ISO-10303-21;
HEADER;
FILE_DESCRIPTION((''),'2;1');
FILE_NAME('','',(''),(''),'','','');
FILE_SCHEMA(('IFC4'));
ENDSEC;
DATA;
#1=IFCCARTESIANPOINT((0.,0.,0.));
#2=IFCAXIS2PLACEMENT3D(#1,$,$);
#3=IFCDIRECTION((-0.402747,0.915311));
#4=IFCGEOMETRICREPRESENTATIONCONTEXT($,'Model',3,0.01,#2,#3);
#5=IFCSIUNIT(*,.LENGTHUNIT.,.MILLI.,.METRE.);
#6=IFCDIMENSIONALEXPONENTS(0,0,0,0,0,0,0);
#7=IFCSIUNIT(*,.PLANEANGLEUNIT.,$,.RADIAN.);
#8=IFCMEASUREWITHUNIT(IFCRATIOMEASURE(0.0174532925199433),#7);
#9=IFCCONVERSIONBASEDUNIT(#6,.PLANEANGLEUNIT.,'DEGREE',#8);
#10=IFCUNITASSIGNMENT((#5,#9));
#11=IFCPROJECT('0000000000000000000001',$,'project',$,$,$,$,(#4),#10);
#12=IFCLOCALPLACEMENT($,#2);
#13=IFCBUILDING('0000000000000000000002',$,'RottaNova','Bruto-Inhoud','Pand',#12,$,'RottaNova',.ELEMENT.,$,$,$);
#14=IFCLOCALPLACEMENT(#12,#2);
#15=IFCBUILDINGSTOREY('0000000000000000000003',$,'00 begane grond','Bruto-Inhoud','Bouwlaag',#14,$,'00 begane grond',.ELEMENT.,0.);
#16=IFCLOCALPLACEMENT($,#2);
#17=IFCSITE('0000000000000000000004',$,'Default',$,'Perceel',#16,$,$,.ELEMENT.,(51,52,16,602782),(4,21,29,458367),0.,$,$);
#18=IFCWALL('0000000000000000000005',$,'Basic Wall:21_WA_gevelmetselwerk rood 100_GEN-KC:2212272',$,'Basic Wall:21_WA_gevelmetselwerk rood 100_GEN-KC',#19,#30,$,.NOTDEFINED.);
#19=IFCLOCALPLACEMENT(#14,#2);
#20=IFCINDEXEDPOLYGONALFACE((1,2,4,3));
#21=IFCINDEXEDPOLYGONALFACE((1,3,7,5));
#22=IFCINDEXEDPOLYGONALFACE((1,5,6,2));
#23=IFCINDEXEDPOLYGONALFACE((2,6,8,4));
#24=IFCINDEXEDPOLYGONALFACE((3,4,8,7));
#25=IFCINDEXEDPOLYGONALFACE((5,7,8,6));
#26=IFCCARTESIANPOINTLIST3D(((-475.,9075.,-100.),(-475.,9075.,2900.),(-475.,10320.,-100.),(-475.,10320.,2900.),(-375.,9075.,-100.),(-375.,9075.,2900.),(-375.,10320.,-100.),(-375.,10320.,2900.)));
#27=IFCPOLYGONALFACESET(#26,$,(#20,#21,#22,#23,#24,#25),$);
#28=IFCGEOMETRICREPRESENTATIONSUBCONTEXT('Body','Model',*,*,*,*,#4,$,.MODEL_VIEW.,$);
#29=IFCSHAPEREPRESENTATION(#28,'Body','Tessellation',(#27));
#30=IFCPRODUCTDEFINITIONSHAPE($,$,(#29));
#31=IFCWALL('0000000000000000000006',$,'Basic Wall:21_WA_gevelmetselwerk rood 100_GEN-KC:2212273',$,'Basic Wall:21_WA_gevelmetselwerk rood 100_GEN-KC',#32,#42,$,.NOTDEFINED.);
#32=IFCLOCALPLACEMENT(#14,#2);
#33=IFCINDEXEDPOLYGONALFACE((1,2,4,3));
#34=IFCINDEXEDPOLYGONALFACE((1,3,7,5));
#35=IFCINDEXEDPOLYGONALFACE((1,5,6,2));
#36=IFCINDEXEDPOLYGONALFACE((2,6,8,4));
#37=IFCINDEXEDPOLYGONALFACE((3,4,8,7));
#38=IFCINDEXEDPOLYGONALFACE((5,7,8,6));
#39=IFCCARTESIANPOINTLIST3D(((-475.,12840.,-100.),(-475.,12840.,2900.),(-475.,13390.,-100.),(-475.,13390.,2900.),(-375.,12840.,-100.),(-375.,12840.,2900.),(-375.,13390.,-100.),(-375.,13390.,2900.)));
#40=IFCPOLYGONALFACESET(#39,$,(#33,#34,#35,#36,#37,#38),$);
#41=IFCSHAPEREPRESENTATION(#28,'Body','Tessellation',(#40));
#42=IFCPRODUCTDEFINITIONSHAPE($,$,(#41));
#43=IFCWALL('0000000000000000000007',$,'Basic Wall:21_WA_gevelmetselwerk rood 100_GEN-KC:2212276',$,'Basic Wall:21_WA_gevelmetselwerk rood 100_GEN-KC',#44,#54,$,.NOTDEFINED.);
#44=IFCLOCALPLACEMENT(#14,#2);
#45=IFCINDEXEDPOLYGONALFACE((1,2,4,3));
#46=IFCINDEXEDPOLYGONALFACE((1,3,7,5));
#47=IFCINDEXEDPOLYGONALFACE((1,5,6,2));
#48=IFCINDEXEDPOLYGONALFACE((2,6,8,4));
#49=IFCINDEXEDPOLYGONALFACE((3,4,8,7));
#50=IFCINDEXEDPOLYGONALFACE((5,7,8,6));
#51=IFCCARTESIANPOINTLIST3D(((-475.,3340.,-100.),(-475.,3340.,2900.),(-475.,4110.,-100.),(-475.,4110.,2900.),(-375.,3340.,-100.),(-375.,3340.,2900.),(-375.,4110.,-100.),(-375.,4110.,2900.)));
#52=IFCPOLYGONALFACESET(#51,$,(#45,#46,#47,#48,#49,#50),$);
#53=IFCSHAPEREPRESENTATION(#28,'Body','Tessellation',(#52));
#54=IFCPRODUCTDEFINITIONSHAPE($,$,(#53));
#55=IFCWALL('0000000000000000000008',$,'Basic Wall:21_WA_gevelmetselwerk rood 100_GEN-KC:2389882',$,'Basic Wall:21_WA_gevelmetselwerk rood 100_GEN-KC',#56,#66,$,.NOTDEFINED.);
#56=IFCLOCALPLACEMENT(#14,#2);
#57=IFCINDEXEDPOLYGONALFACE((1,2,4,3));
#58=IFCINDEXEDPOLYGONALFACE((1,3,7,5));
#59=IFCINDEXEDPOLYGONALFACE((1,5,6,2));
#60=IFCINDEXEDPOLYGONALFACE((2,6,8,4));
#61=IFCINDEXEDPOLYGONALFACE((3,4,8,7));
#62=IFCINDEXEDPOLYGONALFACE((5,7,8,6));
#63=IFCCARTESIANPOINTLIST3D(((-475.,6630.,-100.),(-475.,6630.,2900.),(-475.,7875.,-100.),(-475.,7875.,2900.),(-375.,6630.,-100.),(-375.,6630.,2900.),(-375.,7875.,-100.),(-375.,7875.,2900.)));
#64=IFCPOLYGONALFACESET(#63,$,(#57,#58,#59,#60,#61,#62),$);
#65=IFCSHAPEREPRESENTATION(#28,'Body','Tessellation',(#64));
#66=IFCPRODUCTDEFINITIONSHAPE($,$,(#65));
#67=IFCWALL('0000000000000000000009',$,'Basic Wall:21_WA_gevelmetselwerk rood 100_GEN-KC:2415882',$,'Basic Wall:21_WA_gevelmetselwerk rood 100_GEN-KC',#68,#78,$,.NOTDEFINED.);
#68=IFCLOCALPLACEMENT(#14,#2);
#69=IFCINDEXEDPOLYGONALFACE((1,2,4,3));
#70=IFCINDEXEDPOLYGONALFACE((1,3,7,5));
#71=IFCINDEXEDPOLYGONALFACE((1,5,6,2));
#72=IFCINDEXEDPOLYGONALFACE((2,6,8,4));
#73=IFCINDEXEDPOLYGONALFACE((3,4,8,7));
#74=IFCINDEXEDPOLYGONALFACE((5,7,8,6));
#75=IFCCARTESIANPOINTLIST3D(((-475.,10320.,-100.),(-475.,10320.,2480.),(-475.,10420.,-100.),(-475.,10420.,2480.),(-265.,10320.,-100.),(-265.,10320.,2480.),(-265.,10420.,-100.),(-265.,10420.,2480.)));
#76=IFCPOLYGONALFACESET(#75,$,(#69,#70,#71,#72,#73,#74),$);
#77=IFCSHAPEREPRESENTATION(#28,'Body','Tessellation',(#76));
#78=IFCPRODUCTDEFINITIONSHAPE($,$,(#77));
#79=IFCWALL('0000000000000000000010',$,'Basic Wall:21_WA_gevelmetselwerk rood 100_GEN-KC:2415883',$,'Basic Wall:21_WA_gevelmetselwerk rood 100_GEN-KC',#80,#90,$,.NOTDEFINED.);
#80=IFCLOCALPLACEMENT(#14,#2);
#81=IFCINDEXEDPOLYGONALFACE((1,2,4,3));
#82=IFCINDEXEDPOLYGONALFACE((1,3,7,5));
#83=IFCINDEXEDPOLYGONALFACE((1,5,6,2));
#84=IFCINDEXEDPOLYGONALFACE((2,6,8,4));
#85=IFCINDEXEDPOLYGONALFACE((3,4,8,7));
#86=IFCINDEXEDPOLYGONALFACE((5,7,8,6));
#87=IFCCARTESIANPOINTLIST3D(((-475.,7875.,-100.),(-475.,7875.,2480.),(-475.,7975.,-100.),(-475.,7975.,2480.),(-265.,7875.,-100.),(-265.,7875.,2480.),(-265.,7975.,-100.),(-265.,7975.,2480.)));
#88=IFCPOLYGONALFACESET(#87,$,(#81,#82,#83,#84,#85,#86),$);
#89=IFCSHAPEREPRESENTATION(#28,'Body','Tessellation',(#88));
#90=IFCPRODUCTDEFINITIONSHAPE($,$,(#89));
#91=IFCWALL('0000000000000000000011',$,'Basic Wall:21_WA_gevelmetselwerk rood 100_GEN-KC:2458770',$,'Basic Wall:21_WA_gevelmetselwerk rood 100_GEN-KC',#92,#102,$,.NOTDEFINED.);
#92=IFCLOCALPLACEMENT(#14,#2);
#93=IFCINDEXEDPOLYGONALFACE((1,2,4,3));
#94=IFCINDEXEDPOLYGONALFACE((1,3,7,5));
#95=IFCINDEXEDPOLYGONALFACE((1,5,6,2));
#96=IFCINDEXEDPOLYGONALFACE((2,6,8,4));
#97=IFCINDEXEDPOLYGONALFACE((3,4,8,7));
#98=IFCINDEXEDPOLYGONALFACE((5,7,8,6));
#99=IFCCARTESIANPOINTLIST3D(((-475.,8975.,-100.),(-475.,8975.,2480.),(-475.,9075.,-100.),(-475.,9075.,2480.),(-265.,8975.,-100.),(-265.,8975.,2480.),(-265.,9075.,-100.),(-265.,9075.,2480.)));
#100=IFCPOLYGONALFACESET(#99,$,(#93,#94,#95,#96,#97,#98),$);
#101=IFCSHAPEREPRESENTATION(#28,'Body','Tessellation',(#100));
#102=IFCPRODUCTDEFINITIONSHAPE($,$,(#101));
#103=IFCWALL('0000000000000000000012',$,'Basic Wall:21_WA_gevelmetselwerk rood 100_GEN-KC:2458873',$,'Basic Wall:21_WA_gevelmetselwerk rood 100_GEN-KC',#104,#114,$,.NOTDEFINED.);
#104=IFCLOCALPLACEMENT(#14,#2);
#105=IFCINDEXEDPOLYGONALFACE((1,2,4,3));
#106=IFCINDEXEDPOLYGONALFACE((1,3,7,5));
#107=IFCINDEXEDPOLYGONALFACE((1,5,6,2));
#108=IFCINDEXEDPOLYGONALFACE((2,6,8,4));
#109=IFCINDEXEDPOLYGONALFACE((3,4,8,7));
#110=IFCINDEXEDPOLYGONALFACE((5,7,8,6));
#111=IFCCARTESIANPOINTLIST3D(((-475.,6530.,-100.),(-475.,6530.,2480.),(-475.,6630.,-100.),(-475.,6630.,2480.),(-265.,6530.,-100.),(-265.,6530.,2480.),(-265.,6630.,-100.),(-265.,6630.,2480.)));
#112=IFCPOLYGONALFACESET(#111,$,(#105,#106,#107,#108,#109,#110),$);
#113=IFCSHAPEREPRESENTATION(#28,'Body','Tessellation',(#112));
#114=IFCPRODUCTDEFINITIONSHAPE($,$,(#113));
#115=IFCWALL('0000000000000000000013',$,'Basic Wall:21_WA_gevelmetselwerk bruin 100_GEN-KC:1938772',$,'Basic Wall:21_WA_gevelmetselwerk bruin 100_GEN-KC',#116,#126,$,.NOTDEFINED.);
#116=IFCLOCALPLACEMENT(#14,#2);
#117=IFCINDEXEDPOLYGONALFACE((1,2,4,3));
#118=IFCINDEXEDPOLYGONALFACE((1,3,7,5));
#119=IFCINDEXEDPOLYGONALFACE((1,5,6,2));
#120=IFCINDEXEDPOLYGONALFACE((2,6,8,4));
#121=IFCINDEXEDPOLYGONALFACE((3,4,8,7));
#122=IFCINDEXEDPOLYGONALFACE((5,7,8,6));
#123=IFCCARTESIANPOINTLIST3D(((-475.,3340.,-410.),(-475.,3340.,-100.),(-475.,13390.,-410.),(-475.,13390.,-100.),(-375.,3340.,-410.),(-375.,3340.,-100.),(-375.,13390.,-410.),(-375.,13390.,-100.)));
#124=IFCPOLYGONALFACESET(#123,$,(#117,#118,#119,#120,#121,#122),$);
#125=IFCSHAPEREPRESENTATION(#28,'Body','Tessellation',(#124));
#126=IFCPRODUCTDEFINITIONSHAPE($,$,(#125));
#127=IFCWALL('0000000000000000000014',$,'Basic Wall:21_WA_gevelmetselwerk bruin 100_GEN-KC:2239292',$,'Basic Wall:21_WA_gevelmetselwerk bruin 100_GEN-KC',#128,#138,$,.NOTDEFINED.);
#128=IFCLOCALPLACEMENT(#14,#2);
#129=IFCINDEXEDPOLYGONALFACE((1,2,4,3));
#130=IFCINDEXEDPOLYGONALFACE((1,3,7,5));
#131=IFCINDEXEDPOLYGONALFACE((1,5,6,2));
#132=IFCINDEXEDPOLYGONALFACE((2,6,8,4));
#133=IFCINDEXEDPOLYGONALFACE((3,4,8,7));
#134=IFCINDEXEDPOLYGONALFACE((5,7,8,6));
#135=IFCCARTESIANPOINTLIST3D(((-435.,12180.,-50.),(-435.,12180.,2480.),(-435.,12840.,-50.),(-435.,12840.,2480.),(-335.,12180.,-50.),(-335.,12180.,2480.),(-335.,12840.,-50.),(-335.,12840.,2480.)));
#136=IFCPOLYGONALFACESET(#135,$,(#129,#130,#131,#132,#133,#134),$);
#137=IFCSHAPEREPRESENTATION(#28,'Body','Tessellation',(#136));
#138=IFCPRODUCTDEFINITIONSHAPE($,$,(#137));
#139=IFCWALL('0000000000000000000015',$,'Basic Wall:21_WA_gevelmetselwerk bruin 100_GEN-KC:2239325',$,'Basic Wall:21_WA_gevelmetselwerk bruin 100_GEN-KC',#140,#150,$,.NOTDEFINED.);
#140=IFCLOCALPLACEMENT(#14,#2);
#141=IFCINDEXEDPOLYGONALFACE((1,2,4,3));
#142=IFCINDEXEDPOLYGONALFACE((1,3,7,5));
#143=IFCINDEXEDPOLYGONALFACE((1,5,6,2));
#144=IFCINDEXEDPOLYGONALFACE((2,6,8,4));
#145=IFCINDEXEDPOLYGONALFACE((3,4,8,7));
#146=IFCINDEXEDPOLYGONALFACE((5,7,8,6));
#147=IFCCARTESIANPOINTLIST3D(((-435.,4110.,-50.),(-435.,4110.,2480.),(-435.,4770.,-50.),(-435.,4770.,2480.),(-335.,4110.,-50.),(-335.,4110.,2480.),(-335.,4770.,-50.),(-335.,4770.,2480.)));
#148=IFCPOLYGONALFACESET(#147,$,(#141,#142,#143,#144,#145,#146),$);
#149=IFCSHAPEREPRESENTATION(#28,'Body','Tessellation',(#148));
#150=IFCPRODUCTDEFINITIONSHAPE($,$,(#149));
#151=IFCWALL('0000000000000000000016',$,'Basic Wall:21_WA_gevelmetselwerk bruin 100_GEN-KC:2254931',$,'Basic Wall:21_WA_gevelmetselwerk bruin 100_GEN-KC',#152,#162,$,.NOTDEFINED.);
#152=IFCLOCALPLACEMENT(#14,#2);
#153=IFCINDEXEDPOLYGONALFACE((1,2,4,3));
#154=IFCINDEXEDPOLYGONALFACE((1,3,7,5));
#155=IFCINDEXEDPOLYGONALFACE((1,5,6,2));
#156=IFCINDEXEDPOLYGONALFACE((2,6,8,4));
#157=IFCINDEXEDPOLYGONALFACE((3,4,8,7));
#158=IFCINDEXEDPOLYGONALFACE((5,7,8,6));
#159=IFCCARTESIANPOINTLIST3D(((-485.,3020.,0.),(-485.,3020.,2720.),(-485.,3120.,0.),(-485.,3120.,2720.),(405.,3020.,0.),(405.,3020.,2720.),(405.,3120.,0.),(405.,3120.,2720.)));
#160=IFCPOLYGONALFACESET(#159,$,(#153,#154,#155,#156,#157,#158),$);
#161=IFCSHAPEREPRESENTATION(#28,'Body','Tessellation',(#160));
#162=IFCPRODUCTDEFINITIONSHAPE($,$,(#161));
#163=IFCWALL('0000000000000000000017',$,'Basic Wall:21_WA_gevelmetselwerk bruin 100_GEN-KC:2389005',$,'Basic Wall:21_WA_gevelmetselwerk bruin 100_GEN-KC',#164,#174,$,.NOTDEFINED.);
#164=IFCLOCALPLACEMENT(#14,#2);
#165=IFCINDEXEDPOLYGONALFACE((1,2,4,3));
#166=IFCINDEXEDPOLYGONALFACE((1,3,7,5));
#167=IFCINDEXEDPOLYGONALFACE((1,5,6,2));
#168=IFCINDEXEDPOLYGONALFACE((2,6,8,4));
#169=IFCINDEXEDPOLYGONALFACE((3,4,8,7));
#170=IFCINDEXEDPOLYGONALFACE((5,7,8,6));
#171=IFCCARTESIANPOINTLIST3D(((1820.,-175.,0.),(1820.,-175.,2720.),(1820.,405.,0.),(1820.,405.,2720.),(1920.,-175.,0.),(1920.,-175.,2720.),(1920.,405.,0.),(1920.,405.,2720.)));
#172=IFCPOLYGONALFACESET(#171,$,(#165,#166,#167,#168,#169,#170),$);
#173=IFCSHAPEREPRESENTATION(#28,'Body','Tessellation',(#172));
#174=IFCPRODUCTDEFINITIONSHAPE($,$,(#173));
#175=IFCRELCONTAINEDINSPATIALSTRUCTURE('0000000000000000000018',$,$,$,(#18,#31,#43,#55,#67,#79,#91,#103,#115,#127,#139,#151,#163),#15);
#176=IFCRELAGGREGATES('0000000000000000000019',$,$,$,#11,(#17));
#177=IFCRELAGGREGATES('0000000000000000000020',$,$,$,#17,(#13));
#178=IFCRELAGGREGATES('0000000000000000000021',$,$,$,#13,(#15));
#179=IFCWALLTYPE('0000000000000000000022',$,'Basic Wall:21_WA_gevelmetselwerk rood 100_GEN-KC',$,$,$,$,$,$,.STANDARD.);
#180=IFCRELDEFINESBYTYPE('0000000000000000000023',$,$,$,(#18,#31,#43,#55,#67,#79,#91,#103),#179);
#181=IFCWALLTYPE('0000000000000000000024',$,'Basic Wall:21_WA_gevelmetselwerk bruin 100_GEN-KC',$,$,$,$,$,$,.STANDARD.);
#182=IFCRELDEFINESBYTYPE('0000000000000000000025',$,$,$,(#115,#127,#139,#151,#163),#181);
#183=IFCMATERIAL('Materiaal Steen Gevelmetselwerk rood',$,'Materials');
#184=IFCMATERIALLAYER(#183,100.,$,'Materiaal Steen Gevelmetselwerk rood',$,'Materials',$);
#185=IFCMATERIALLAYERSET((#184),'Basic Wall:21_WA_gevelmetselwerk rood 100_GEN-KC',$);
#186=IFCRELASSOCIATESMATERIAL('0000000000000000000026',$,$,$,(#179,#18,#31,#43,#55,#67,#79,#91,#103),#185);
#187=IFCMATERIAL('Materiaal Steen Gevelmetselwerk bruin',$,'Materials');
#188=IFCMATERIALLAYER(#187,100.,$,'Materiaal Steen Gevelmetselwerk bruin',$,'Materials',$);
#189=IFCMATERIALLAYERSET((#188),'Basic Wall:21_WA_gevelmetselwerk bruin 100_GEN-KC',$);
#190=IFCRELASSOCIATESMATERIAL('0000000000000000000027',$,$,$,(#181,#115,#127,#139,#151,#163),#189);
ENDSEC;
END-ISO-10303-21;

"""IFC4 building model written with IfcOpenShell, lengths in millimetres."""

from ifc_helpers import new_model, entity, si_unit, converted_unit, direction, frame, frame_2d, origin, place, context, subcontext, project, spatial, rectangle, extrude, material, layer, layer_set, type_object, element, save


model = new_model("IFC4")

# Units and contexts
model_context = context("Model", 3, precision=0.01, world=origin(), true_north=direction((-0.402747, 0.915311)))
body_context = subcontext(model_context, "Body", "Model", "MODEL_VIEW")
ifc_project = project(units=[si_unit("LENGTHUNIT", "METRE", prefix="MILLI"), converted_unit("PLANEANGLEUNIT", "DEGREE", entity("IfcRatioMeasure", 0.0174532925199433), si_unit("PLANEANGLEUNIT", "RADIAN"), dimensions=[0, 0, 0, 0, 0, 0, 0])], contexts=[model_context])

# Site, building, storey
site_placement = place(None, origin())
site = spatial("IfcSite", under=ifc_project, at=site_placement, Name="Default", ObjectType="Perceel", CompositionType="ELEMENT", RefLatitude=(51, 52, 16, 602782), RefLongitude=(4, 21, 29, 458367), RefElevation=0.0)
building_placement = place(None, origin())
building = spatial("IfcBuilding", under=site, at=building_placement, Name="RottaNova", Description="Bruto-Inhoud", ObjectType="Pand", LongName="RottaNova", CompositionType="ELEMENT")
storey_placement = place(building_placement, origin())
storey = spatial("IfcBuildingStorey", under=building, at=storey_placement, Name="00 begane grond", Description="Bruto-Inhoud", ObjectType="Bouwlaag", LongName="00 begane grond", CompositionType="ELEMENT", Elevation=0.0)

# Walls
ifc_material_1 = material(Name="Materiaal Steen Gevelmetselwerk rood", Category="Materials")
ifc_layer_1 = layer(ifc_material_1, 100.0, Name="Materiaal Steen Gevelmetselwerk rood", Category="Materials")
ifc_layer_set_1 = layer_set([ifc_layer_1], Name="Basic Wall:21_WA_gevelmetselwerk rood 100_GEN-KC")
wall_type_1 = type_object("IfcWallType", Name="Basic Wall:21_WA_gevelmetselwerk rood 100_GEN-KC", PredefinedType="STANDARD", material=ifc_layer_set_1)
wall_1_placement = place(storey_placement, frame((-425.0, 9075.0, -100.0), z_axis=(0.0, 0.0, 1.0), x_axis=(0.0, 1.0, 0.0)))
element("IfcWall", 1, at=wall_1_placement, inside=storey, type_object=wall_type_1, material=ifc_layer_set_1, Name="Basic Wall:21_WA_gevelmetselwerk rood 100_GEN-KC:2212272", ObjectType="Basic Wall:21_WA_gevelmetselwerk rood 100_GEN-KC", PredefinedType="NOTDEFINED", context=body_context, shape_type="SweptSolid", body=[
    extrude(rectangle(XDim=1245.0, YDim=100.0, at=frame_2d((622.5, 0.0), x_axis=(-1.0, 0.0))), origin(), (0.0, 0.0, 1.0), 3000.0),
])
wall_2_placement = place(storey_placement, frame((-425.0, 12840.0, -100.0), z_axis=(0.0, 0.0, 1.0), x_axis=(0.0, 1.0, 0.0)))
element("IfcWall", 2, at=wall_2_placement, inside=storey, type_object=wall_type_1, material=ifc_layer_set_1, Name="Basic Wall:21_WA_gevelmetselwerk rood 100_GEN-KC:2212273", ObjectType="Basic Wall:21_WA_gevelmetselwerk rood 100_GEN-KC", PredefinedType="NOTDEFINED", context=body_context, shape_type="SweptSolid", body=[
    extrude(rectangle(XDim=550.0, YDim=100.0, at=frame_2d((275.0, 0.0), x_axis=(-1.0, 0.0))), origin(), (0.0, 0.0, 1.0), 3000.0),
])
wall_3_placement = place(storey_placement, frame((-425.0, 3340.0, -100.0), z_axis=(0.0, 0.0, 1.0), x_axis=(0.0, 1.0, 0.0)))
element("IfcWall", 3, at=wall_3_placement, inside=storey, type_object=wall_type_1, material=ifc_layer_set_1, Name="Basic Wall:21_WA_gevelmetselwerk rood 100_GEN-KC:2212276", ObjectType="Basic Wall:21_WA_gevelmetselwerk rood 100_GEN-KC", PredefinedType="NOTDEFINED", context=body_context, shape_type="SweptSolid", body=[
    extrude(rectangle(XDim=770.0, YDim=100.0, at=frame_2d((385.0, 0.0), x_axis=(-1.0, 0.0))), origin(), (0.0, 0.0, 1.0), 3000.0),
])
wall_4_placement = place(storey_placement, frame((-425.0, 6630.0, -100.0), z_axis=(0.0, 0.0, 1.0), x_axis=(0.0, 1.0, 0.0)))
element("IfcWall", 4, at=wall_4_placement, inside=storey, type_object=wall_type_1, material=ifc_layer_set_1, Name="Basic Wall:21_WA_gevelmetselwerk rood 100_GEN-KC:2389882", ObjectType="Basic Wall:21_WA_gevelmetselwerk rood 100_GEN-KC", PredefinedType="NOTDEFINED", context=body_context, shape_type="SweptSolid", body=[
    extrude(rectangle(XDim=1245.0, YDim=100.0, at=frame_2d((622.5, 0.0), x_axis=(-1.0, 0.0))), origin(), (0.0, 0.0, 1.0), 3000.0),
])
wall_5_placement = place(storey_placement, frame((-475.0, 10370.0, -100.0)))
element("IfcWall", 5, at=wall_5_placement, inside=storey, type_object=wall_type_1, material=ifc_layer_set_1, Name="Basic Wall:21_WA_gevelmetselwerk rood 100_GEN-KC:2415882", ObjectType="Basic Wall:21_WA_gevelmetselwerk rood 100_GEN-KC", PredefinedType="NOTDEFINED", context=body_context, shape_type="SweptSolid", body=[
    extrude(rectangle(XDim=210.0, YDim=100.0, at=frame_2d((105.0, 0.0), x_axis=(-1.0, 0.0))), origin(), (0.0, 0.0, 1.0), 2580.0),
])
wall_6_placement = place(storey_placement, frame((-475.0, 7925.0, -100.0)))
element("IfcWall", 6, at=wall_6_placement, inside=storey, type_object=wall_type_1, material=ifc_layer_set_1, Name="Basic Wall:21_WA_gevelmetselwerk rood 100_GEN-KC:2415883", ObjectType="Basic Wall:21_WA_gevelmetselwerk rood 100_GEN-KC", PredefinedType="NOTDEFINED", context=body_context, shape_type="SweptSolid", body=[
    extrude(rectangle(XDim=210.0, YDim=100.0, at=frame_2d((105.0, 0.0), x_axis=(-1.0, 0.0))), origin(), (0.0, 0.0, 1.0), 2580.0),
])
wall_7_placement = place(storey_placement, frame((-475.0, 9025.0, -100.0)))
element("IfcWall", 7, at=wall_7_placement, inside=storey, type_object=wall_type_1, material=ifc_layer_set_1, Name="Basic Wall:21_WA_gevelmetselwerk rood 100_GEN-KC:2458770", ObjectType="Basic Wall:21_WA_gevelmetselwerk rood 100_GEN-KC", PredefinedType="NOTDEFINED", context=body_context, shape_type="SweptSolid", body=[
    extrude(rectangle(XDim=210.0, YDim=100.0, at=frame_2d((105.0, 0.0), x_axis=(-1.0, 0.0))), origin(), (0.0, 0.0, 1.0), 2580.0),
])
wall_8_placement = place(storey_placement, frame((-475.0, 6580.0, -100.0)))
element("IfcWall", 8, at=wall_8_placement, inside=storey, type_object=wall_type_1, material=ifc_layer_set_1, Name="Basic Wall:21_WA_gevelmetselwerk rood 100_GEN-KC:2458873", ObjectType="Basic Wall:21_WA_gevelmetselwerk rood 100_GEN-KC", PredefinedType="NOTDEFINED", context=body_context, shape_type="SweptSolid", body=[
    extrude(rectangle(XDim=210.0, YDim=100.0, at=frame_2d((105.0, 0.0), x_axis=(-1.0, 0.0))), origin(), (0.0, 0.0, 1.0), 2580.0),
])
ifc_material_2 = material(Name="Materiaal Steen Gevelmetselwerk bruin", Category="Materials")
ifc_layer_2 = layer(ifc_material_2, 100.0, Name="Materiaal Steen Gevelmetselwerk bruin", Category="Materials")
ifc_layer_set_2 = layer_set([ifc_layer_2], Name="Basic Wall:21_WA_gevelmetselwerk bruin 100_GEN-KC")
wall_type_2 = type_object("IfcWallType", Name="Basic Wall:21_WA_gevelmetselwerk bruin 100_GEN-KC", PredefinedType="STANDARD", material=ifc_layer_set_2)
wall_9_placement = place(storey_placement, frame((-425.0, 3340.0, -410.0), z_axis=(0.0, 0.0, 1.0), x_axis=(0.0, 1.0, 0.0)))
element("IfcWall", 9, at=wall_9_placement, inside=storey, type_object=wall_type_2, material=ifc_layer_set_2, Name="Basic Wall:21_WA_gevelmetselwerk bruin 100_GEN-KC:1938772", ObjectType="Basic Wall:21_WA_gevelmetselwerk bruin 100_GEN-KC", PredefinedType="NOTDEFINED", context=body_context, shape_type="SweptSolid", body=[
    extrude(rectangle(XDim=10050.0, YDim=100.0, at=frame_2d((5025.0, 0.0), x_axis=(-1.0, 0.0))), origin(), (0.0, 0.0, 1.0), 310.0),
])
wall_10_placement = place(storey_placement, frame((-385.0, 12840.0, -50.0), z_axis=(0.0, 0.0, 1.0), x_axis=(0.0, -1.0, 0.0)))
element("IfcWall", 10, at=wall_10_placement, inside=storey, type_object=wall_type_2, material=ifc_layer_set_2, Name="Basic Wall:21_WA_gevelmetselwerk bruin 100_GEN-KC:2239292", ObjectType="Basic Wall:21_WA_gevelmetselwerk bruin 100_GEN-KC", PredefinedType="NOTDEFINED", context=body_context, shape_type="SweptSolid", body=[
    extrude(rectangle(XDim=660.0, YDim=100.0, at=frame_2d((330.0, 0.0), x_axis=(-1.0, 0.0))), origin(), (0.0, 0.0, 1.0), 2530.0),
])
wall_11_placement = place(storey_placement, frame((-385.0, 4110.0, -50.0), z_axis=(0.0, 0.0, 1.0), x_axis=(0.0, 1.0, 0.0)))
element("IfcWall", 11, at=wall_11_placement, inside=storey, type_object=wall_type_2, material=ifc_layer_set_2, Name="Basic Wall:21_WA_gevelmetselwerk bruin 100_GEN-KC:2239325", ObjectType="Basic Wall:21_WA_gevelmetselwerk bruin 100_GEN-KC", PredefinedType="NOTDEFINED", context=body_context, shape_type="SweptSolid", body=[
    extrude(rectangle(XDim=660.0, YDim=100.0, at=frame_2d((330.0, 0.0), x_axis=(-1.0, 0.0))), origin(), (0.0, 0.0, 1.0), 2530.0),
])
wall_12_placement = place(storey_placement, frame((405.0, 3070.0, 0.0), z_axis=(0.0, 0.0, 1.0), x_axis=(-1.0, 0.0, 0.0)))
element("IfcWall", 12, at=wall_12_placement, inside=storey, type_object=wall_type_2, material=ifc_layer_set_2, Name="Basic Wall:21_WA_gevelmetselwerk bruin 100_GEN-KC:2254931", ObjectType="Basic Wall:21_WA_gevelmetselwerk bruin 100_GEN-KC", PredefinedType="NOTDEFINED", context=body_context, shape_type="SweptSolid", body=[
    extrude(rectangle(XDim=890.0, YDim=100.0, at=frame_2d((445.0, 0.0), x_axis=(-1.0, 0.0))), origin(), (0.0, 0.0, 1.0), 2720.0),
])
wall_13_placement = place(storey_placement, frame((1870.0, 405.0, 0.0), z_axis=(0.0, 0.0, 1.0), x_axis=(0.0, -1.0, 0.0)))
element("IfcWall", 13, at=wall_13_placement, inside=storey, type_object=wall_type_2, material=ifc_layer_set_2, Name="Basic Wall:21_WA_gevelmetselwerk bruin 100_GEN-KC:2389005", ObjectType="Basic Wall:21_WA_gevelmetselwerk bruin 100_GEN-KC", PredefinedType="NOTDEFINED", context=body_context, shape_type="SweptSolid", body=[
    extrude(rectangle(XDim=580.0, YDim=100.0, at=frame_2d((290.0, 0.0), x_axis=(-1.0, 0.0))), origin(), (0.0, 0.0, 1.0), 2720.0),
])

save(model, "model.ifc")
